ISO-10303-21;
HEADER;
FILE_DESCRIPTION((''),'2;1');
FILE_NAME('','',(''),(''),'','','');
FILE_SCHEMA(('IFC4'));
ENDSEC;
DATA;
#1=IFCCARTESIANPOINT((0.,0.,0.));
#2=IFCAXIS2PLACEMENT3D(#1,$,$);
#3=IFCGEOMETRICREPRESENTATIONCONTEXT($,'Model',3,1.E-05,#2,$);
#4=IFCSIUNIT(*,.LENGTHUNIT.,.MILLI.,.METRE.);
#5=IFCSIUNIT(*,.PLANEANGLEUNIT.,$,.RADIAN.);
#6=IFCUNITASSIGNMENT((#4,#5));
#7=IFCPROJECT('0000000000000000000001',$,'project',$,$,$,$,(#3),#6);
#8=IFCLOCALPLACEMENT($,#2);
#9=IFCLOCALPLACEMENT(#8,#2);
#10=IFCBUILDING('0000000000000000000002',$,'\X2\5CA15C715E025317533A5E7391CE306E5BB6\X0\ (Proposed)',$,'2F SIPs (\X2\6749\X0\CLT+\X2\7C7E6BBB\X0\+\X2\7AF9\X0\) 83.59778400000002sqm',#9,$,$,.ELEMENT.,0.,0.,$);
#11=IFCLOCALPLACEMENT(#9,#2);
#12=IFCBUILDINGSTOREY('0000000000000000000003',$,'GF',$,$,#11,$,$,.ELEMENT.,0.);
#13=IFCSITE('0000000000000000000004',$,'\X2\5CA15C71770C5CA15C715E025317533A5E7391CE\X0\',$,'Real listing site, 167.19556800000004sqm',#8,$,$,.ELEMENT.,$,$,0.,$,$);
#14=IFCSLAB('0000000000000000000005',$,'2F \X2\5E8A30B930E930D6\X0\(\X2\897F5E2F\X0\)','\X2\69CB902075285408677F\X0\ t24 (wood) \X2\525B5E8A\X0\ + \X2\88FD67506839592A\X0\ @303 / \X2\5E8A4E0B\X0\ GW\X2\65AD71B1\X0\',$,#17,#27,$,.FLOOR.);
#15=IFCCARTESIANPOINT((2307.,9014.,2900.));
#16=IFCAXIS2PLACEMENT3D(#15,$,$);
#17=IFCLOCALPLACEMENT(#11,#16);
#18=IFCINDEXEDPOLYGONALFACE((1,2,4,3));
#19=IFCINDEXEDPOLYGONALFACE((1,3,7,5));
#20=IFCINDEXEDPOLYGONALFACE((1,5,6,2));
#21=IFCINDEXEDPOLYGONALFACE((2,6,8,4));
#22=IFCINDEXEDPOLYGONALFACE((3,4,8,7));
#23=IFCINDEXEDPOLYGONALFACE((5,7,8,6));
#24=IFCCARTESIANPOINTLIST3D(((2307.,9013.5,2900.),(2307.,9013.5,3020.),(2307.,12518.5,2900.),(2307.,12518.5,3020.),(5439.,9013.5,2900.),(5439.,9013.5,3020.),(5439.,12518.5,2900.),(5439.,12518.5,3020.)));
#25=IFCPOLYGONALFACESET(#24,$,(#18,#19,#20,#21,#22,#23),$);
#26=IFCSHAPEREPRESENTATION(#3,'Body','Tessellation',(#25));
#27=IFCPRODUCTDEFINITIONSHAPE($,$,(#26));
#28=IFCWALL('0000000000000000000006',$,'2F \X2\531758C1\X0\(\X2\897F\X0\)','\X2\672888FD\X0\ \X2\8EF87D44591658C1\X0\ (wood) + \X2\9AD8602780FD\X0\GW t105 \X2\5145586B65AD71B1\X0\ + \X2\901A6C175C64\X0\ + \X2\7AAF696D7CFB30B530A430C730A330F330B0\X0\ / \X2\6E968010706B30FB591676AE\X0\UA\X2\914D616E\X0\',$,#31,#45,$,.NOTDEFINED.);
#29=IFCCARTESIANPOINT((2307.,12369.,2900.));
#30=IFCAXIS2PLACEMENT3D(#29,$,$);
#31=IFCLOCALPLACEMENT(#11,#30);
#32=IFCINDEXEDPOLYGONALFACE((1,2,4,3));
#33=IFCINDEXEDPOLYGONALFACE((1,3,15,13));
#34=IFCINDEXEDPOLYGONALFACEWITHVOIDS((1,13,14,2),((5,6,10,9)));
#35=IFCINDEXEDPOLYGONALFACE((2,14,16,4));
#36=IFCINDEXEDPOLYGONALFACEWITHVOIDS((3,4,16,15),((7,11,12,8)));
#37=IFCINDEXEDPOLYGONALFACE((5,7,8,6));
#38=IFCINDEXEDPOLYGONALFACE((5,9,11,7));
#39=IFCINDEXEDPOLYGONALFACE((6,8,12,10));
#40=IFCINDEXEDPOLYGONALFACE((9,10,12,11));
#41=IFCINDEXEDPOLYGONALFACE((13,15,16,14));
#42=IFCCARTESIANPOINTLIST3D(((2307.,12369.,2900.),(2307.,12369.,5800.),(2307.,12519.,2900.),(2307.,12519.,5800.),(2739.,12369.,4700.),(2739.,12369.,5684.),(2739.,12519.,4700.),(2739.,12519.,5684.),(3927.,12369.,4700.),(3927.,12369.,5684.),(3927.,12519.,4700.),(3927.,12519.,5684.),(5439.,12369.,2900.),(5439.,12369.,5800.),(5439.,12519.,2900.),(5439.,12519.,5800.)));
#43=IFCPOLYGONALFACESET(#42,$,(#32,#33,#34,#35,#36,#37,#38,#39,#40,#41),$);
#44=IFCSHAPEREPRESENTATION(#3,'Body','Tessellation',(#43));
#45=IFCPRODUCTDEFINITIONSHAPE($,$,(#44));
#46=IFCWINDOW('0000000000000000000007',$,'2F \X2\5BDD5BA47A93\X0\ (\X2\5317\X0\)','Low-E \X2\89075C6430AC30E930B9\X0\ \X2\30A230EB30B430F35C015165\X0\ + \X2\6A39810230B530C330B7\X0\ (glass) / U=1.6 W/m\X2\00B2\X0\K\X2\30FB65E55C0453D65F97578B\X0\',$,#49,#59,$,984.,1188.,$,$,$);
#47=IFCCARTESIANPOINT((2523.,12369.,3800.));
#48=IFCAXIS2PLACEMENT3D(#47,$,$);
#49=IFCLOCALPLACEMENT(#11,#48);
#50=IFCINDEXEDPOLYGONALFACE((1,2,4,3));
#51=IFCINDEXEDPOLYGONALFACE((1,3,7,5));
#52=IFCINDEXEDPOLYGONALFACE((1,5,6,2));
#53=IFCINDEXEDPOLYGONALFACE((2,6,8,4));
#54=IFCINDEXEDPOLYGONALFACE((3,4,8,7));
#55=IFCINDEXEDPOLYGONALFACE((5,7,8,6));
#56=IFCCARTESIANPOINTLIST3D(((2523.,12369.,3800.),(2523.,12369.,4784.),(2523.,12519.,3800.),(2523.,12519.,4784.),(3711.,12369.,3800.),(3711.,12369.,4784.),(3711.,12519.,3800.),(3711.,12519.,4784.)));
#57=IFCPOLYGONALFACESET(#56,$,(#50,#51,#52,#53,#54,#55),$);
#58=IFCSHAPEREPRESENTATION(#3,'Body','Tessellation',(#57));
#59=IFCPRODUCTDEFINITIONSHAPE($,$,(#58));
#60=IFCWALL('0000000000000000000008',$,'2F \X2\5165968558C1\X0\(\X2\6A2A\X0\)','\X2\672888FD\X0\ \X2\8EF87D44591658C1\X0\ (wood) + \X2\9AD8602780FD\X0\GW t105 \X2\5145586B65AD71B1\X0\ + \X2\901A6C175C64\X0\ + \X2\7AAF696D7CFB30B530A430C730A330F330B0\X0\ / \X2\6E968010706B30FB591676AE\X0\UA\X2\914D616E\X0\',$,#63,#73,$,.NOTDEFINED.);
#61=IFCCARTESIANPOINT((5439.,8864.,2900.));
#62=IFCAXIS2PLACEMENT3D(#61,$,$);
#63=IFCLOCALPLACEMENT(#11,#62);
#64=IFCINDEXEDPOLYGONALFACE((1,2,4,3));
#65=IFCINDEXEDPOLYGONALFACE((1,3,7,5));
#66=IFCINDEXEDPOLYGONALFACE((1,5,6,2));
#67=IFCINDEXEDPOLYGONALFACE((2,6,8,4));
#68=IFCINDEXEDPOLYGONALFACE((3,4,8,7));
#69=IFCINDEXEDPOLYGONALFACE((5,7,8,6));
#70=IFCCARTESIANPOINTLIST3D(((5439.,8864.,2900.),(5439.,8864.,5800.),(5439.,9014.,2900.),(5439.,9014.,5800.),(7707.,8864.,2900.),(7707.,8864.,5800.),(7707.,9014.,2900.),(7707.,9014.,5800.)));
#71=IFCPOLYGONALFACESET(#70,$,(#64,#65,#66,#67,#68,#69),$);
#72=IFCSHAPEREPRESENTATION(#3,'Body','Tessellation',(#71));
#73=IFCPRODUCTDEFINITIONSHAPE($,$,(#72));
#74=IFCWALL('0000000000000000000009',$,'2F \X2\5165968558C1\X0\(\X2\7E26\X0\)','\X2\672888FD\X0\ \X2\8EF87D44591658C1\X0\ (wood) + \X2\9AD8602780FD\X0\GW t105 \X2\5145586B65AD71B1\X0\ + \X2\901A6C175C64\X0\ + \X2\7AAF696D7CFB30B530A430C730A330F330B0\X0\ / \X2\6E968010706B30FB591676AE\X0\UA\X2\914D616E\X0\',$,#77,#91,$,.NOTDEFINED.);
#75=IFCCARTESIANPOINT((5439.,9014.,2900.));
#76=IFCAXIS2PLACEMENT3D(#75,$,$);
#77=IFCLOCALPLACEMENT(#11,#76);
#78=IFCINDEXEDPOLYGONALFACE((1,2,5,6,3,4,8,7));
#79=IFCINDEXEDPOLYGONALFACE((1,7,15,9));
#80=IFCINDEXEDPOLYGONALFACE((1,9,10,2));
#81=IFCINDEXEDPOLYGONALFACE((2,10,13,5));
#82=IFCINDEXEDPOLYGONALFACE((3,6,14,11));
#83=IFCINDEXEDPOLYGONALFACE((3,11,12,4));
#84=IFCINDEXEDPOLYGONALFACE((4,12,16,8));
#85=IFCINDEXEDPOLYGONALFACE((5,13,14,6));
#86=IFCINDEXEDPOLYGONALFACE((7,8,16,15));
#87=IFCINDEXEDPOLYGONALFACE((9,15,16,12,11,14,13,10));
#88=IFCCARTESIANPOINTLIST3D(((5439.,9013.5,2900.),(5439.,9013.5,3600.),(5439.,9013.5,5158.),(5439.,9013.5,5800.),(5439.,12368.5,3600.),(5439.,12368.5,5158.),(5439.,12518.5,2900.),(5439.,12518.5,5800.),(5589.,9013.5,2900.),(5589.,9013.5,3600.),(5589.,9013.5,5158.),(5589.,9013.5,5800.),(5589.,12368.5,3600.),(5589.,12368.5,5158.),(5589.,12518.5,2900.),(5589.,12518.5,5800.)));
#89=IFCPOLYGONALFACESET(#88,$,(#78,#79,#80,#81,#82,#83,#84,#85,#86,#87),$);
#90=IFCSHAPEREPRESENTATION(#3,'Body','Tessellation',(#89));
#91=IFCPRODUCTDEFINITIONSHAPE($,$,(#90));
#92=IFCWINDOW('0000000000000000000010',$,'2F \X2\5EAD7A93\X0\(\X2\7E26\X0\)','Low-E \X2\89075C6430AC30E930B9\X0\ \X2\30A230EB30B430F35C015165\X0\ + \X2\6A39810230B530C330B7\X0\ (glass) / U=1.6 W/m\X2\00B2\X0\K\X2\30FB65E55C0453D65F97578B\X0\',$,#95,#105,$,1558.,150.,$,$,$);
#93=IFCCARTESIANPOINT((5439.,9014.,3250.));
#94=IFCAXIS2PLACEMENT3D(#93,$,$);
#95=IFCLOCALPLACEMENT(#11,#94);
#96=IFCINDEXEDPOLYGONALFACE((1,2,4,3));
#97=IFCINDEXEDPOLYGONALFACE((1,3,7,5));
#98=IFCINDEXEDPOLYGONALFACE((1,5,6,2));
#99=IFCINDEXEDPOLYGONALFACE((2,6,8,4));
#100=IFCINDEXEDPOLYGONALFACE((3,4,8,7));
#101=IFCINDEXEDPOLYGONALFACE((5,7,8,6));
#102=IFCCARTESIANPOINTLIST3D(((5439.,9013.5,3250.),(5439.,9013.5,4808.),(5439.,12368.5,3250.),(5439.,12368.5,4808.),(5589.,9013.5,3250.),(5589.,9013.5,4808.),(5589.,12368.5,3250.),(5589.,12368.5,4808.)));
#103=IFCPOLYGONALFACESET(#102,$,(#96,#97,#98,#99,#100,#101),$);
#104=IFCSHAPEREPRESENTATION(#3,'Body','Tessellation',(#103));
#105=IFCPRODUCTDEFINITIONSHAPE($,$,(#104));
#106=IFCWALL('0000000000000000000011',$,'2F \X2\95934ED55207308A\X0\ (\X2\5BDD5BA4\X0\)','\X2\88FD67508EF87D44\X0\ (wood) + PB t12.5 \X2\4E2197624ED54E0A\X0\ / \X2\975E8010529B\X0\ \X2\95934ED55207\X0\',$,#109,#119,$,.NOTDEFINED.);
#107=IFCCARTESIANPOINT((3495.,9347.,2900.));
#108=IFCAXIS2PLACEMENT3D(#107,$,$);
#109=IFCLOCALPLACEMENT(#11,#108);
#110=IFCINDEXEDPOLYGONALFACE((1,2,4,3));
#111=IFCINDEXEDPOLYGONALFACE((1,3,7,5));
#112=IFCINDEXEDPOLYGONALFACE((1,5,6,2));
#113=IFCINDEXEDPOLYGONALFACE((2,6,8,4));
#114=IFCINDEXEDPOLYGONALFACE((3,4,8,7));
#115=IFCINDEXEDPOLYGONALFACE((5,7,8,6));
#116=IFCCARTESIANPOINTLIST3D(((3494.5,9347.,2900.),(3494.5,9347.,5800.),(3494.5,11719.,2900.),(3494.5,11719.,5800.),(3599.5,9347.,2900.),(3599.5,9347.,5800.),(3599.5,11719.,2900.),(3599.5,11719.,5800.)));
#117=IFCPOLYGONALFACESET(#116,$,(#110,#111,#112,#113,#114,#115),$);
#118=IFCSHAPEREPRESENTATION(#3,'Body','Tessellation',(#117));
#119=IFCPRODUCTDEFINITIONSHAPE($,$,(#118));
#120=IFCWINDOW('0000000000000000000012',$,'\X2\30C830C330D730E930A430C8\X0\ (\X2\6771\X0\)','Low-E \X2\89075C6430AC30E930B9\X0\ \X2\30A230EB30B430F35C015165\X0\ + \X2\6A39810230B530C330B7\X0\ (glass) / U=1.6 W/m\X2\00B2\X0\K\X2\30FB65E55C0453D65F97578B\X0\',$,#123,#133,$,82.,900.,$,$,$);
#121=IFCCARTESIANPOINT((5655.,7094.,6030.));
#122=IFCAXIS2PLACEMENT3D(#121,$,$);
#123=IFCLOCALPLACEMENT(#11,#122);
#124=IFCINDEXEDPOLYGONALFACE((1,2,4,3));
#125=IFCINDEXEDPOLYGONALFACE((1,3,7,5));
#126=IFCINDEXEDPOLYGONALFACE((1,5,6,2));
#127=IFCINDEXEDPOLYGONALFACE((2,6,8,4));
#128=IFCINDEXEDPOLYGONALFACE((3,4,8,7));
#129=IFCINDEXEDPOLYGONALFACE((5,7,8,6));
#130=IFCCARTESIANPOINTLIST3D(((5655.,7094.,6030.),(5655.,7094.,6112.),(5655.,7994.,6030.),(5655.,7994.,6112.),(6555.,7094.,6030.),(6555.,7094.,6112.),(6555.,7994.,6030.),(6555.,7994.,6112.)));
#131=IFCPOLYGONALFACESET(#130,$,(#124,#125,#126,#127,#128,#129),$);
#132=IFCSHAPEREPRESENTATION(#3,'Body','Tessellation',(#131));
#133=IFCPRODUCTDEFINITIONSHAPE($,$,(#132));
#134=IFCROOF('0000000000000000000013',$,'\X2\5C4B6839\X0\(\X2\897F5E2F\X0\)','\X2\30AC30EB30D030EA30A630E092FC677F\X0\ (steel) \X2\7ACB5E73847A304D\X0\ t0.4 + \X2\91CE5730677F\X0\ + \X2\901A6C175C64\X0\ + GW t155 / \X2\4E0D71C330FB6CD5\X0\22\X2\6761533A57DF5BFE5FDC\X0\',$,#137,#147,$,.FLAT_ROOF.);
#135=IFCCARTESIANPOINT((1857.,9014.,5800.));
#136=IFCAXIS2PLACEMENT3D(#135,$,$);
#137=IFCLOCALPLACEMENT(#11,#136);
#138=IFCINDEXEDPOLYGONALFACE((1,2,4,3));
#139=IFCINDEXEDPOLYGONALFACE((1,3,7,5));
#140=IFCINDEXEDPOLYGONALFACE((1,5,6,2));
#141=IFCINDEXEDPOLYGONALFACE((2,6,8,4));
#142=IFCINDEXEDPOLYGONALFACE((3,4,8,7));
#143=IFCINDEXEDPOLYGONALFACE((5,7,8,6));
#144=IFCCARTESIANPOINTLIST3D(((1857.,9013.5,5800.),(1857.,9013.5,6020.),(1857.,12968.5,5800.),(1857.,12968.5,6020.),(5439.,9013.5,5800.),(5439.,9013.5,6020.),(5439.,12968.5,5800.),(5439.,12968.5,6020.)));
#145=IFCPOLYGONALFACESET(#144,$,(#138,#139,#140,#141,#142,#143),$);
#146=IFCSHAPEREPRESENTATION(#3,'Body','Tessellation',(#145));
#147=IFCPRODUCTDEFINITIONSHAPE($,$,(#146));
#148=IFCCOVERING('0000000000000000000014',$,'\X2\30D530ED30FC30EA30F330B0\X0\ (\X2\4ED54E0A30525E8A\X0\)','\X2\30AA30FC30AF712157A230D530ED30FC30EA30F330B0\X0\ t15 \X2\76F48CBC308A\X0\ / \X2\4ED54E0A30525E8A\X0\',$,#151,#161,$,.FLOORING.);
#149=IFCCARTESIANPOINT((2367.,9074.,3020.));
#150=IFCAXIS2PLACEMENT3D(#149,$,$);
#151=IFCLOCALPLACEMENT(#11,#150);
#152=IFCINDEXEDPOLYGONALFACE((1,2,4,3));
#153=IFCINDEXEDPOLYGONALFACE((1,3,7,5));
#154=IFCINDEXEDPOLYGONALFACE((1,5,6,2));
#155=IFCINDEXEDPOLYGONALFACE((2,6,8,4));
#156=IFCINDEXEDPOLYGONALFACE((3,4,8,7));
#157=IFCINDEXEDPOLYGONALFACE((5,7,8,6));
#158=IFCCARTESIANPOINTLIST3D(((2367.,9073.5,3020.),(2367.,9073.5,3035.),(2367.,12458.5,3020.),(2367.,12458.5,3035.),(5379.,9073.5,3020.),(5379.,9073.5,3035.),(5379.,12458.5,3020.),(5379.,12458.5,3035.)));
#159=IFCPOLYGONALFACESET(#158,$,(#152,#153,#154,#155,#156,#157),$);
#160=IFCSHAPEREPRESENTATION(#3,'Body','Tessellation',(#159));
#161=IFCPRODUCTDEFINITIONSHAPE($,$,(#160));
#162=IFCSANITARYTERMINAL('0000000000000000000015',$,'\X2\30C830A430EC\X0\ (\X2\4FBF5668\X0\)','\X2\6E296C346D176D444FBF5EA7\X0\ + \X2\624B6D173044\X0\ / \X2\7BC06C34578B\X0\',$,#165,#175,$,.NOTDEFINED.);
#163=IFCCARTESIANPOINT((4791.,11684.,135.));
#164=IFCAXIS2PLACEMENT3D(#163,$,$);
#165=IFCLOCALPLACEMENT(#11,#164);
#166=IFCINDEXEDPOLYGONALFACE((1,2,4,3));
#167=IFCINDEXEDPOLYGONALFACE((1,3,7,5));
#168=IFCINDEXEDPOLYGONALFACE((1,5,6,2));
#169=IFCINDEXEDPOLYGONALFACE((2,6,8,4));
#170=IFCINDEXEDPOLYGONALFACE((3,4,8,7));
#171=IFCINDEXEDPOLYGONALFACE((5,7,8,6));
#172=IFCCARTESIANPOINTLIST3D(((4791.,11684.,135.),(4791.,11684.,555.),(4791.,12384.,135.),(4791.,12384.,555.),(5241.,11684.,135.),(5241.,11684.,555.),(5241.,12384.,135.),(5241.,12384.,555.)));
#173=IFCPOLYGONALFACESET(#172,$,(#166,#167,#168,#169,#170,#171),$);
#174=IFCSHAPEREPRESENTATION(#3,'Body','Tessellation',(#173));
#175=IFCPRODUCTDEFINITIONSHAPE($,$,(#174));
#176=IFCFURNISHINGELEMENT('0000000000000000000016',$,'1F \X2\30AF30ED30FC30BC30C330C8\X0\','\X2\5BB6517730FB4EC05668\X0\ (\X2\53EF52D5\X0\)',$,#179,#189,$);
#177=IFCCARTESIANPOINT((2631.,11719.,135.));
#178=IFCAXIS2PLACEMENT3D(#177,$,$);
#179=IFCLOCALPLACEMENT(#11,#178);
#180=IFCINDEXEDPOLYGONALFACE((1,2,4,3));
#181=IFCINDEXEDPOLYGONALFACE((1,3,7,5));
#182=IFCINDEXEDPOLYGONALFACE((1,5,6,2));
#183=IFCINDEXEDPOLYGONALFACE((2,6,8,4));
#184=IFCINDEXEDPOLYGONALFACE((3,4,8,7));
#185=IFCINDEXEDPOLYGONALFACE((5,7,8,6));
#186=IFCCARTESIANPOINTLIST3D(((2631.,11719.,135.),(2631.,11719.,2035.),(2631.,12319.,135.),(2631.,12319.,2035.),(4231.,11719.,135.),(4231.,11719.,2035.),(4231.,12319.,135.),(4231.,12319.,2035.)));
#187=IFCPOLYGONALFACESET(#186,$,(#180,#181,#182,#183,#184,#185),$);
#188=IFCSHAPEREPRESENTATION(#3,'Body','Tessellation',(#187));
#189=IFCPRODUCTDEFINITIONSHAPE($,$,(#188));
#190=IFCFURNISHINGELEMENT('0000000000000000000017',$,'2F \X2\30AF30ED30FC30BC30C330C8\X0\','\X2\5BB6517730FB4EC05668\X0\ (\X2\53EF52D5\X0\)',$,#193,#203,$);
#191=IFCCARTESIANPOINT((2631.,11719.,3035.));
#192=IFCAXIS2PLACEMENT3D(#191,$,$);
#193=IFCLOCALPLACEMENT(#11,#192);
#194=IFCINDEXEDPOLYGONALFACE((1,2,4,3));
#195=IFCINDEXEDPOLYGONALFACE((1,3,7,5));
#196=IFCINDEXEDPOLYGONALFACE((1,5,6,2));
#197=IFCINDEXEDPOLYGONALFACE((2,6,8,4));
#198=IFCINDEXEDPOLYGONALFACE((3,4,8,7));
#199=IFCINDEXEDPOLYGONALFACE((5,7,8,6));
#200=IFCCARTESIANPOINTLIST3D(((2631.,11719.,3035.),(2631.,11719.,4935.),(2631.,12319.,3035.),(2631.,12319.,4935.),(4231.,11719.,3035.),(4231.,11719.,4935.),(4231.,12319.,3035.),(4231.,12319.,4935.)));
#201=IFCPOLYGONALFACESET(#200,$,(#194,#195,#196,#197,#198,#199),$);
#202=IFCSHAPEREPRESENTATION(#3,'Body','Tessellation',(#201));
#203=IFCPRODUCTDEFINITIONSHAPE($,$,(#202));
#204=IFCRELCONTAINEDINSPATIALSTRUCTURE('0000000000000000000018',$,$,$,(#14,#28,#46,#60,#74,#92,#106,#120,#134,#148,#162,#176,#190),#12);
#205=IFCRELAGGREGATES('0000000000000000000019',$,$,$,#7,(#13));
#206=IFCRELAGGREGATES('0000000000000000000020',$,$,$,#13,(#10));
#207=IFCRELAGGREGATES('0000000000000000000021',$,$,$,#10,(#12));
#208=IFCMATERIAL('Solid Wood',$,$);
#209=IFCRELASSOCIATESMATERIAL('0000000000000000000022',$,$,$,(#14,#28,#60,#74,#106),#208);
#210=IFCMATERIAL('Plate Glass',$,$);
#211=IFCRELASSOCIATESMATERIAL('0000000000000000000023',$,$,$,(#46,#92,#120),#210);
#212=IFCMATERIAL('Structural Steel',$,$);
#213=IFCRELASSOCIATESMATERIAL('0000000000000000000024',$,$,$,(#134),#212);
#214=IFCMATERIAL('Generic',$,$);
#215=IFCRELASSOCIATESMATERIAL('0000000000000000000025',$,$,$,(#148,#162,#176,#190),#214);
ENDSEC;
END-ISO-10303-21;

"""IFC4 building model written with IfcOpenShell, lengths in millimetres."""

from ifc_helpers import new_model, si_unit, frame, frame_2d, origin, place, context, project, spatial, rectangle, extrude, material, element, fill, save


model = new_model("IFC4")

# Units and contexts
model_context = context("Model", 3, precision=1e-05, world=origin())
ifc_project = project(units=[si_unit("LENGTHUNIT", "METRE", prefix="MILLI"), si_unit("PLANEANGLEUNIT", "RADIAN")], contexts=[model_context])

# Site, building, storey
site_placement = place(None, origin())
site = spatial("IfcSite", under=ifc_project, at=site_placement, Name="岡山県岡山市北区平野", ObjectType="Real listing site, 167.19556800000004sqm", CompositionType="ELEMENT", RefElevation=0.0)
building_placement = place(site_placement, origin())
building = spatial("IfcBuilding", under=site, at=building_placement, Name="岡山市北区平野の家 (Proposed)", ObjectType="2F SIPs (杉CLT+籾殻+竹) 83.59778400000002sqm", CompositionType="ELEMENT", ElevationOfRefHeight=0.0, ElevationOfTerrain=0.0)
storey_placement = place(building_placement, origin())
storey = spatial("IfcBuildingStorey", under=building, at=storey_placement, Name="GF", CompositionType="ELEMENT", Elevation=0.0)

# Slab
ifc_material_1 = material(Name="Solid Wood")
slab_placement = place(storey_placement, frame((2307.0, 9014.0, 2900.0)))
element("IfcSlab", 1, at=slab_placement, inside=storey, material=ifc_material_1, Name="2F 床スラブ(西帯)", Description="構造用合板 t24 (wood) 剛床 + 製材根太 @303 / 床下 GW断熱", PredefinedType="FLOOR", context=model_context, shape_type="SweptSolid", body=[
    extrude(rectangle(XDim=3132.0, YDim=3505.0, at=frame_2d((1566.0, 1752.0))), frame((2307.0, 9014.0, 2900.0)), (0.0, 0.0, 1.0), 120.0),
])

# Wall, opening, window
wall_1_placement = place(storey_placement, frame((2307.0, 12369.0, 2900.0)))
wall_1 = element("IfcWall", 2, at=wall_1_placement, inside=storey, material=ifc_material_1, Name="2F 北壁(西)", Description="木製 軸組外壁 (wood) + 高性能GW t105 充填断熱 + 通気層 + 窯業系サイディング / 準耐火・外皮UA配慮", PredefinedType="NOTDEFINED", context=model_context, shape_type="SweptSolid", body=[
    extrude(rectangle(XDim=3132.0, YDim=150.0, at=frame_2d((1566.0, 75.0))), frame((2307.0, 12369.0, 2900.0)), (0.0, 0.0, 1.0), 2900.0),
])
opening_1_placement = place(storey_placement, frame((2523.0, 12369.0, 3800.0)))
opening_1 = element("IfcOpeningElement", 3, at=opening_1_placement, cuts=wall_1, PredefinedType="NOTDEFINED", context=model_context, shape_type="SweptSolid", body=[
    extrude(rectangle(XDim=1188.0, YDim=150.0, at=frame_2d((594.0, 75.0))), frame((2523.0, 12369.0, 3800.0)), (0.0, 0.0, 1.0), 984.0),
])
ifc_material_2 = material(Name="Plate Glass")
window_1_placement = place(storey_placement, frame((2523.0, 12369.0, 3800.0)))
window_1 = element("IfcWindow", 4, at=window_1_placement, inside=storey, material=ifc_material_2, Name="2F 寝室窓 (北)", Description="Low-E 複層ガラス アルゴン封入 + 樹脂サッシ (glass) / U=1.6 W/m²K・日射取得型", OverallHeight=984.0, OverallWidth=1188.0, context=model_context, shape_type="SweptSolid", body=[
    extrude(rectangle(XDim=1188.0, YDim=150.0, at=frame_2d((594.0, 75.0))), frame((2523.0, 12369.0, 3800.0)), (0.0, 0.0, 1.0), 984.0),
])
fill(opening_1, window_1)

# Wall
wall_2_placement = place(storey_placement, frame((5439.0, 8864.0, 2900.0)))
element("IfcWall", 5, at=wall_2_placement, inside=storey, material=ifc_material_1, Name="2F 入隅壁(横)", Description="木製 軸組外壁 (wood) + 高性能GW t105 充填断熱 + 通気層 + 窯業系サイディング / 準耐火・外皮UA配慮", PredefinedType="NOTDEFINED", context=model_context, shape_type="SweptSolid", body=[
    extrude(rectangle(XDim=2268.0, YDim=150.0, at=frame_2d((1134.0, 75.0))), frame((5439.0, 8864.0, 2900.0)), (0.0, 0.0, 1.0), 2900.0),
])

# Wall, opening, window
wall_3_placement = place(storey_placement, frame((5439.0, 9014.0, 2900.0)))
wall_3 = element("IfcWall", 6, at=wall_3_placement, inside=storey, material=ifc_material_1, Name="2F 入隅壁(縦)", Description="木製 軸組外壁 (wood) + 高性能GW t105 充填断熱 + 通気層 + 窯業系サイディング / 準耐火・外皮UA配慮", PredefinedType="NOTDEFINED", context=model_context, shape_type="SweptSolid", body=[
    extrude(rectangle(XDim=150.0, YDim=3505.0, at=frame_2d((75.0, 1752.0))), frame((5439.0, 9014.0, 2900.0)), (0.0, 0.0, 1.0), 2900.0),
])
opening_2_placement = place(storey_placement, frame((5439.0, 9014.0, 3250.0)))
opening_2 = element("IfcOpeningElement", 7, at=opening_2_placement, cuts=wall_3, PredefinedType="NOTDEFINED", context=model_context, shape_type="SweptSolid", body=[
    extrude(rectangle(XDim=150.0, YDim=3355.0, at=frame_2d((75.0, 1677.0))), frame((5439.0, 9014.0, 3250.0)), (0.0, 0.0, 1.0), 1558.0),
])
window_2_placement = place(storey_placement, frame((5439.0, 9014.0, 3250.0)))
window_2 = element("IfcWindow", 8, at=window_2_placement, inside=storey, material=ifc_material_2, Name="2F 庭窓(縦)", Description="Low-E 複層ガラス アルゴン封入 + 樹脂サッシ (glass) / U=1.6 W/m²K・日射取得型", OverallHeight=1558.0, OverallWidth=150.0, context=model_context, shape_type="SweptSolid", body=[
    extrude(rectangle(XDim=150.0, YDim=3355.0, at=frame_2d((75.0, 1677.0))), frame((5439.0, 9014.0, 3250.0)), (0.0, 0.0, 1.0), 1558.0),
])
fill(opening_2, window_2)

# Wall
wall_4_placement = place(storey_placement, frame((3495.0, 9347.0, 2900.0)))
element("IfcWall", 9, at=wall_4_placement, inside=storey, material=ifc_material_1, Name="2F 間仕切り (寝室)", Description="製材軸組 (wood) + PB t12.5 両面仕上 / 非耐力 間仕切", PredefinedType="NOTDEFINED", context=model_context, shape_type="SweptSolid", body=[
    extrude(rectangle(XDim=105.0, YDim=2372.0, at=frame_2d((52.0, 1186.0))), frame((3495.0, 9347.0, 2900.0)), (0.0, 0.0, 1.0), 2900.0),
])

# Window
window_3_placement = place(storey_placement, frame((5655.0, 7094.0, 6030.0)))
element("IfcWindow", 10, at=window_3_placement, inside=storey, material=ifc_material_2, Name="トップライト (東)", Description="Low-E 複層ガラス アルゴン封入 + 樹脂サッシ (glass) / U=1.6 W/m²K・日射取得型", OverallHeight=82.0, OverallWidth=900.0, context=model_context, shape_type="SweptSolid", body=[
    extrude(rectangle(XDim=900.0, YDim=900.0, at=frame_2d((450.0, 450.0))), frame((5655.0, 7094.0, 6030.0)), (0.0, 0.0, 1.0), 82.0),
])

# Roof
ifc_material_3 = material(Name="Structural Steel")
for number, where, name in (
    (11, (1857.0, 9014.0, 5800.0), "屋根(西帯)"),
):
    element("IfcRoof", number, at=place(storey_placement, frame(where)), inside=storey, material=ifc_material_3, Name=name, Description="ガルバリウム鋼板 (steel) 立平葺き t0.4 + 野地板 + 通気層 + GW t155 / 不燃・法22条区域対応", PredefinedType="FLAT_ROOF", context=model_context, shape_type="SweptSolid", body=[
        extrude(rectangle(XDim=3582.0, YDim=3955.0, at=frame_2d((1791.0, 1977.0))), frame((1857.0, 9014.0, 5800.0)), (0.0, 0.0, 1.0), 220.0),
    ])

# Covering
ifc_material_4 = material(Name="Generic")
covering_placement = place(storey_placement, frame((2367.0, 9074.0, 3020.0)))
element("IfcCovering", 12, at=covering_placement, inside=storey, material=ifc_material_4, Name="フローリング (仕上げ床)", Description="オーク無垢フローリング t15 直貼り / 仕上げ床", PredefinedType="FLOORING", context=model_context, shape_type="SweptSolid", body=[
    extrude(rectangle(XDim=3012.0, YDim=3385.0, at=frame_2d((1506.0, 1692.0))), frame((2367.0, 9074.0, 3020.0)), (0.0, 0.0, 1.0), 15.0),
])

# Sanitary terminal
sanitary_terminal_placement = place(storey_placement, frame((4791.0, 11684.0, 135.0)))
element("IfcSanitaryTerminal", 13, at=sanitary_terminal_placement, inside=storey, material=ifc_material_4, Name="トイレ (便器)", Description="温水洗浄便座 + 手洗い / 節水型", PredefinedType="NOTDEFINED", context=model_context, shape_type="SweptSolid", body=[
    extrude(rectangle(XDim=450.0, YDim=700.0, at=frame_2d((225.0, 350.0))), frame((4791.0, 11684.0, 135.0)), (0.0, 0.0, 1.0), 420.0),
])

# Furnishing elements
furnishing_1_placement = place(storey_placement, frame((2631.0, 11719.0, 135.0)))
element("IfcFurnishingElement", 14, at=furnishing_1_placement, inside=storey, material=ifc_material_4, Name="1F クローゼット", Description="家具・什器 (可動)", context=model_context, shape_type="SweptSolid", body=[
    extrude(rectangle(XDim=1600.0, YDim=600.0, at=frame_2d((800.0, 300.0))), frame((2631.0, 11719.0, 135.0)), (0.0, 0.0, 1.0), 1900.0),
])
furnishing_2_placement = place(storey_placement, frame((2631.0, 11719.0, 3035.0)))
element("IfcFurnishingElement", 15, at=furnishing_2_placement, inside=storey, material=ifc_material_4, Name="2F クローゼット", Description="家具・什器 (可動)", context=model_context, shape_type="SweptSolid", body=[
    extrude(rectangle(XDim=1600.0, YDim=600.0, at=frame_2d((800.0, 300.0))), frame((2631.0, 11719.0, 3035.0)), (0.0, 0.0, 1.0), 1900.0),
])

save(model, "model.ifc")
